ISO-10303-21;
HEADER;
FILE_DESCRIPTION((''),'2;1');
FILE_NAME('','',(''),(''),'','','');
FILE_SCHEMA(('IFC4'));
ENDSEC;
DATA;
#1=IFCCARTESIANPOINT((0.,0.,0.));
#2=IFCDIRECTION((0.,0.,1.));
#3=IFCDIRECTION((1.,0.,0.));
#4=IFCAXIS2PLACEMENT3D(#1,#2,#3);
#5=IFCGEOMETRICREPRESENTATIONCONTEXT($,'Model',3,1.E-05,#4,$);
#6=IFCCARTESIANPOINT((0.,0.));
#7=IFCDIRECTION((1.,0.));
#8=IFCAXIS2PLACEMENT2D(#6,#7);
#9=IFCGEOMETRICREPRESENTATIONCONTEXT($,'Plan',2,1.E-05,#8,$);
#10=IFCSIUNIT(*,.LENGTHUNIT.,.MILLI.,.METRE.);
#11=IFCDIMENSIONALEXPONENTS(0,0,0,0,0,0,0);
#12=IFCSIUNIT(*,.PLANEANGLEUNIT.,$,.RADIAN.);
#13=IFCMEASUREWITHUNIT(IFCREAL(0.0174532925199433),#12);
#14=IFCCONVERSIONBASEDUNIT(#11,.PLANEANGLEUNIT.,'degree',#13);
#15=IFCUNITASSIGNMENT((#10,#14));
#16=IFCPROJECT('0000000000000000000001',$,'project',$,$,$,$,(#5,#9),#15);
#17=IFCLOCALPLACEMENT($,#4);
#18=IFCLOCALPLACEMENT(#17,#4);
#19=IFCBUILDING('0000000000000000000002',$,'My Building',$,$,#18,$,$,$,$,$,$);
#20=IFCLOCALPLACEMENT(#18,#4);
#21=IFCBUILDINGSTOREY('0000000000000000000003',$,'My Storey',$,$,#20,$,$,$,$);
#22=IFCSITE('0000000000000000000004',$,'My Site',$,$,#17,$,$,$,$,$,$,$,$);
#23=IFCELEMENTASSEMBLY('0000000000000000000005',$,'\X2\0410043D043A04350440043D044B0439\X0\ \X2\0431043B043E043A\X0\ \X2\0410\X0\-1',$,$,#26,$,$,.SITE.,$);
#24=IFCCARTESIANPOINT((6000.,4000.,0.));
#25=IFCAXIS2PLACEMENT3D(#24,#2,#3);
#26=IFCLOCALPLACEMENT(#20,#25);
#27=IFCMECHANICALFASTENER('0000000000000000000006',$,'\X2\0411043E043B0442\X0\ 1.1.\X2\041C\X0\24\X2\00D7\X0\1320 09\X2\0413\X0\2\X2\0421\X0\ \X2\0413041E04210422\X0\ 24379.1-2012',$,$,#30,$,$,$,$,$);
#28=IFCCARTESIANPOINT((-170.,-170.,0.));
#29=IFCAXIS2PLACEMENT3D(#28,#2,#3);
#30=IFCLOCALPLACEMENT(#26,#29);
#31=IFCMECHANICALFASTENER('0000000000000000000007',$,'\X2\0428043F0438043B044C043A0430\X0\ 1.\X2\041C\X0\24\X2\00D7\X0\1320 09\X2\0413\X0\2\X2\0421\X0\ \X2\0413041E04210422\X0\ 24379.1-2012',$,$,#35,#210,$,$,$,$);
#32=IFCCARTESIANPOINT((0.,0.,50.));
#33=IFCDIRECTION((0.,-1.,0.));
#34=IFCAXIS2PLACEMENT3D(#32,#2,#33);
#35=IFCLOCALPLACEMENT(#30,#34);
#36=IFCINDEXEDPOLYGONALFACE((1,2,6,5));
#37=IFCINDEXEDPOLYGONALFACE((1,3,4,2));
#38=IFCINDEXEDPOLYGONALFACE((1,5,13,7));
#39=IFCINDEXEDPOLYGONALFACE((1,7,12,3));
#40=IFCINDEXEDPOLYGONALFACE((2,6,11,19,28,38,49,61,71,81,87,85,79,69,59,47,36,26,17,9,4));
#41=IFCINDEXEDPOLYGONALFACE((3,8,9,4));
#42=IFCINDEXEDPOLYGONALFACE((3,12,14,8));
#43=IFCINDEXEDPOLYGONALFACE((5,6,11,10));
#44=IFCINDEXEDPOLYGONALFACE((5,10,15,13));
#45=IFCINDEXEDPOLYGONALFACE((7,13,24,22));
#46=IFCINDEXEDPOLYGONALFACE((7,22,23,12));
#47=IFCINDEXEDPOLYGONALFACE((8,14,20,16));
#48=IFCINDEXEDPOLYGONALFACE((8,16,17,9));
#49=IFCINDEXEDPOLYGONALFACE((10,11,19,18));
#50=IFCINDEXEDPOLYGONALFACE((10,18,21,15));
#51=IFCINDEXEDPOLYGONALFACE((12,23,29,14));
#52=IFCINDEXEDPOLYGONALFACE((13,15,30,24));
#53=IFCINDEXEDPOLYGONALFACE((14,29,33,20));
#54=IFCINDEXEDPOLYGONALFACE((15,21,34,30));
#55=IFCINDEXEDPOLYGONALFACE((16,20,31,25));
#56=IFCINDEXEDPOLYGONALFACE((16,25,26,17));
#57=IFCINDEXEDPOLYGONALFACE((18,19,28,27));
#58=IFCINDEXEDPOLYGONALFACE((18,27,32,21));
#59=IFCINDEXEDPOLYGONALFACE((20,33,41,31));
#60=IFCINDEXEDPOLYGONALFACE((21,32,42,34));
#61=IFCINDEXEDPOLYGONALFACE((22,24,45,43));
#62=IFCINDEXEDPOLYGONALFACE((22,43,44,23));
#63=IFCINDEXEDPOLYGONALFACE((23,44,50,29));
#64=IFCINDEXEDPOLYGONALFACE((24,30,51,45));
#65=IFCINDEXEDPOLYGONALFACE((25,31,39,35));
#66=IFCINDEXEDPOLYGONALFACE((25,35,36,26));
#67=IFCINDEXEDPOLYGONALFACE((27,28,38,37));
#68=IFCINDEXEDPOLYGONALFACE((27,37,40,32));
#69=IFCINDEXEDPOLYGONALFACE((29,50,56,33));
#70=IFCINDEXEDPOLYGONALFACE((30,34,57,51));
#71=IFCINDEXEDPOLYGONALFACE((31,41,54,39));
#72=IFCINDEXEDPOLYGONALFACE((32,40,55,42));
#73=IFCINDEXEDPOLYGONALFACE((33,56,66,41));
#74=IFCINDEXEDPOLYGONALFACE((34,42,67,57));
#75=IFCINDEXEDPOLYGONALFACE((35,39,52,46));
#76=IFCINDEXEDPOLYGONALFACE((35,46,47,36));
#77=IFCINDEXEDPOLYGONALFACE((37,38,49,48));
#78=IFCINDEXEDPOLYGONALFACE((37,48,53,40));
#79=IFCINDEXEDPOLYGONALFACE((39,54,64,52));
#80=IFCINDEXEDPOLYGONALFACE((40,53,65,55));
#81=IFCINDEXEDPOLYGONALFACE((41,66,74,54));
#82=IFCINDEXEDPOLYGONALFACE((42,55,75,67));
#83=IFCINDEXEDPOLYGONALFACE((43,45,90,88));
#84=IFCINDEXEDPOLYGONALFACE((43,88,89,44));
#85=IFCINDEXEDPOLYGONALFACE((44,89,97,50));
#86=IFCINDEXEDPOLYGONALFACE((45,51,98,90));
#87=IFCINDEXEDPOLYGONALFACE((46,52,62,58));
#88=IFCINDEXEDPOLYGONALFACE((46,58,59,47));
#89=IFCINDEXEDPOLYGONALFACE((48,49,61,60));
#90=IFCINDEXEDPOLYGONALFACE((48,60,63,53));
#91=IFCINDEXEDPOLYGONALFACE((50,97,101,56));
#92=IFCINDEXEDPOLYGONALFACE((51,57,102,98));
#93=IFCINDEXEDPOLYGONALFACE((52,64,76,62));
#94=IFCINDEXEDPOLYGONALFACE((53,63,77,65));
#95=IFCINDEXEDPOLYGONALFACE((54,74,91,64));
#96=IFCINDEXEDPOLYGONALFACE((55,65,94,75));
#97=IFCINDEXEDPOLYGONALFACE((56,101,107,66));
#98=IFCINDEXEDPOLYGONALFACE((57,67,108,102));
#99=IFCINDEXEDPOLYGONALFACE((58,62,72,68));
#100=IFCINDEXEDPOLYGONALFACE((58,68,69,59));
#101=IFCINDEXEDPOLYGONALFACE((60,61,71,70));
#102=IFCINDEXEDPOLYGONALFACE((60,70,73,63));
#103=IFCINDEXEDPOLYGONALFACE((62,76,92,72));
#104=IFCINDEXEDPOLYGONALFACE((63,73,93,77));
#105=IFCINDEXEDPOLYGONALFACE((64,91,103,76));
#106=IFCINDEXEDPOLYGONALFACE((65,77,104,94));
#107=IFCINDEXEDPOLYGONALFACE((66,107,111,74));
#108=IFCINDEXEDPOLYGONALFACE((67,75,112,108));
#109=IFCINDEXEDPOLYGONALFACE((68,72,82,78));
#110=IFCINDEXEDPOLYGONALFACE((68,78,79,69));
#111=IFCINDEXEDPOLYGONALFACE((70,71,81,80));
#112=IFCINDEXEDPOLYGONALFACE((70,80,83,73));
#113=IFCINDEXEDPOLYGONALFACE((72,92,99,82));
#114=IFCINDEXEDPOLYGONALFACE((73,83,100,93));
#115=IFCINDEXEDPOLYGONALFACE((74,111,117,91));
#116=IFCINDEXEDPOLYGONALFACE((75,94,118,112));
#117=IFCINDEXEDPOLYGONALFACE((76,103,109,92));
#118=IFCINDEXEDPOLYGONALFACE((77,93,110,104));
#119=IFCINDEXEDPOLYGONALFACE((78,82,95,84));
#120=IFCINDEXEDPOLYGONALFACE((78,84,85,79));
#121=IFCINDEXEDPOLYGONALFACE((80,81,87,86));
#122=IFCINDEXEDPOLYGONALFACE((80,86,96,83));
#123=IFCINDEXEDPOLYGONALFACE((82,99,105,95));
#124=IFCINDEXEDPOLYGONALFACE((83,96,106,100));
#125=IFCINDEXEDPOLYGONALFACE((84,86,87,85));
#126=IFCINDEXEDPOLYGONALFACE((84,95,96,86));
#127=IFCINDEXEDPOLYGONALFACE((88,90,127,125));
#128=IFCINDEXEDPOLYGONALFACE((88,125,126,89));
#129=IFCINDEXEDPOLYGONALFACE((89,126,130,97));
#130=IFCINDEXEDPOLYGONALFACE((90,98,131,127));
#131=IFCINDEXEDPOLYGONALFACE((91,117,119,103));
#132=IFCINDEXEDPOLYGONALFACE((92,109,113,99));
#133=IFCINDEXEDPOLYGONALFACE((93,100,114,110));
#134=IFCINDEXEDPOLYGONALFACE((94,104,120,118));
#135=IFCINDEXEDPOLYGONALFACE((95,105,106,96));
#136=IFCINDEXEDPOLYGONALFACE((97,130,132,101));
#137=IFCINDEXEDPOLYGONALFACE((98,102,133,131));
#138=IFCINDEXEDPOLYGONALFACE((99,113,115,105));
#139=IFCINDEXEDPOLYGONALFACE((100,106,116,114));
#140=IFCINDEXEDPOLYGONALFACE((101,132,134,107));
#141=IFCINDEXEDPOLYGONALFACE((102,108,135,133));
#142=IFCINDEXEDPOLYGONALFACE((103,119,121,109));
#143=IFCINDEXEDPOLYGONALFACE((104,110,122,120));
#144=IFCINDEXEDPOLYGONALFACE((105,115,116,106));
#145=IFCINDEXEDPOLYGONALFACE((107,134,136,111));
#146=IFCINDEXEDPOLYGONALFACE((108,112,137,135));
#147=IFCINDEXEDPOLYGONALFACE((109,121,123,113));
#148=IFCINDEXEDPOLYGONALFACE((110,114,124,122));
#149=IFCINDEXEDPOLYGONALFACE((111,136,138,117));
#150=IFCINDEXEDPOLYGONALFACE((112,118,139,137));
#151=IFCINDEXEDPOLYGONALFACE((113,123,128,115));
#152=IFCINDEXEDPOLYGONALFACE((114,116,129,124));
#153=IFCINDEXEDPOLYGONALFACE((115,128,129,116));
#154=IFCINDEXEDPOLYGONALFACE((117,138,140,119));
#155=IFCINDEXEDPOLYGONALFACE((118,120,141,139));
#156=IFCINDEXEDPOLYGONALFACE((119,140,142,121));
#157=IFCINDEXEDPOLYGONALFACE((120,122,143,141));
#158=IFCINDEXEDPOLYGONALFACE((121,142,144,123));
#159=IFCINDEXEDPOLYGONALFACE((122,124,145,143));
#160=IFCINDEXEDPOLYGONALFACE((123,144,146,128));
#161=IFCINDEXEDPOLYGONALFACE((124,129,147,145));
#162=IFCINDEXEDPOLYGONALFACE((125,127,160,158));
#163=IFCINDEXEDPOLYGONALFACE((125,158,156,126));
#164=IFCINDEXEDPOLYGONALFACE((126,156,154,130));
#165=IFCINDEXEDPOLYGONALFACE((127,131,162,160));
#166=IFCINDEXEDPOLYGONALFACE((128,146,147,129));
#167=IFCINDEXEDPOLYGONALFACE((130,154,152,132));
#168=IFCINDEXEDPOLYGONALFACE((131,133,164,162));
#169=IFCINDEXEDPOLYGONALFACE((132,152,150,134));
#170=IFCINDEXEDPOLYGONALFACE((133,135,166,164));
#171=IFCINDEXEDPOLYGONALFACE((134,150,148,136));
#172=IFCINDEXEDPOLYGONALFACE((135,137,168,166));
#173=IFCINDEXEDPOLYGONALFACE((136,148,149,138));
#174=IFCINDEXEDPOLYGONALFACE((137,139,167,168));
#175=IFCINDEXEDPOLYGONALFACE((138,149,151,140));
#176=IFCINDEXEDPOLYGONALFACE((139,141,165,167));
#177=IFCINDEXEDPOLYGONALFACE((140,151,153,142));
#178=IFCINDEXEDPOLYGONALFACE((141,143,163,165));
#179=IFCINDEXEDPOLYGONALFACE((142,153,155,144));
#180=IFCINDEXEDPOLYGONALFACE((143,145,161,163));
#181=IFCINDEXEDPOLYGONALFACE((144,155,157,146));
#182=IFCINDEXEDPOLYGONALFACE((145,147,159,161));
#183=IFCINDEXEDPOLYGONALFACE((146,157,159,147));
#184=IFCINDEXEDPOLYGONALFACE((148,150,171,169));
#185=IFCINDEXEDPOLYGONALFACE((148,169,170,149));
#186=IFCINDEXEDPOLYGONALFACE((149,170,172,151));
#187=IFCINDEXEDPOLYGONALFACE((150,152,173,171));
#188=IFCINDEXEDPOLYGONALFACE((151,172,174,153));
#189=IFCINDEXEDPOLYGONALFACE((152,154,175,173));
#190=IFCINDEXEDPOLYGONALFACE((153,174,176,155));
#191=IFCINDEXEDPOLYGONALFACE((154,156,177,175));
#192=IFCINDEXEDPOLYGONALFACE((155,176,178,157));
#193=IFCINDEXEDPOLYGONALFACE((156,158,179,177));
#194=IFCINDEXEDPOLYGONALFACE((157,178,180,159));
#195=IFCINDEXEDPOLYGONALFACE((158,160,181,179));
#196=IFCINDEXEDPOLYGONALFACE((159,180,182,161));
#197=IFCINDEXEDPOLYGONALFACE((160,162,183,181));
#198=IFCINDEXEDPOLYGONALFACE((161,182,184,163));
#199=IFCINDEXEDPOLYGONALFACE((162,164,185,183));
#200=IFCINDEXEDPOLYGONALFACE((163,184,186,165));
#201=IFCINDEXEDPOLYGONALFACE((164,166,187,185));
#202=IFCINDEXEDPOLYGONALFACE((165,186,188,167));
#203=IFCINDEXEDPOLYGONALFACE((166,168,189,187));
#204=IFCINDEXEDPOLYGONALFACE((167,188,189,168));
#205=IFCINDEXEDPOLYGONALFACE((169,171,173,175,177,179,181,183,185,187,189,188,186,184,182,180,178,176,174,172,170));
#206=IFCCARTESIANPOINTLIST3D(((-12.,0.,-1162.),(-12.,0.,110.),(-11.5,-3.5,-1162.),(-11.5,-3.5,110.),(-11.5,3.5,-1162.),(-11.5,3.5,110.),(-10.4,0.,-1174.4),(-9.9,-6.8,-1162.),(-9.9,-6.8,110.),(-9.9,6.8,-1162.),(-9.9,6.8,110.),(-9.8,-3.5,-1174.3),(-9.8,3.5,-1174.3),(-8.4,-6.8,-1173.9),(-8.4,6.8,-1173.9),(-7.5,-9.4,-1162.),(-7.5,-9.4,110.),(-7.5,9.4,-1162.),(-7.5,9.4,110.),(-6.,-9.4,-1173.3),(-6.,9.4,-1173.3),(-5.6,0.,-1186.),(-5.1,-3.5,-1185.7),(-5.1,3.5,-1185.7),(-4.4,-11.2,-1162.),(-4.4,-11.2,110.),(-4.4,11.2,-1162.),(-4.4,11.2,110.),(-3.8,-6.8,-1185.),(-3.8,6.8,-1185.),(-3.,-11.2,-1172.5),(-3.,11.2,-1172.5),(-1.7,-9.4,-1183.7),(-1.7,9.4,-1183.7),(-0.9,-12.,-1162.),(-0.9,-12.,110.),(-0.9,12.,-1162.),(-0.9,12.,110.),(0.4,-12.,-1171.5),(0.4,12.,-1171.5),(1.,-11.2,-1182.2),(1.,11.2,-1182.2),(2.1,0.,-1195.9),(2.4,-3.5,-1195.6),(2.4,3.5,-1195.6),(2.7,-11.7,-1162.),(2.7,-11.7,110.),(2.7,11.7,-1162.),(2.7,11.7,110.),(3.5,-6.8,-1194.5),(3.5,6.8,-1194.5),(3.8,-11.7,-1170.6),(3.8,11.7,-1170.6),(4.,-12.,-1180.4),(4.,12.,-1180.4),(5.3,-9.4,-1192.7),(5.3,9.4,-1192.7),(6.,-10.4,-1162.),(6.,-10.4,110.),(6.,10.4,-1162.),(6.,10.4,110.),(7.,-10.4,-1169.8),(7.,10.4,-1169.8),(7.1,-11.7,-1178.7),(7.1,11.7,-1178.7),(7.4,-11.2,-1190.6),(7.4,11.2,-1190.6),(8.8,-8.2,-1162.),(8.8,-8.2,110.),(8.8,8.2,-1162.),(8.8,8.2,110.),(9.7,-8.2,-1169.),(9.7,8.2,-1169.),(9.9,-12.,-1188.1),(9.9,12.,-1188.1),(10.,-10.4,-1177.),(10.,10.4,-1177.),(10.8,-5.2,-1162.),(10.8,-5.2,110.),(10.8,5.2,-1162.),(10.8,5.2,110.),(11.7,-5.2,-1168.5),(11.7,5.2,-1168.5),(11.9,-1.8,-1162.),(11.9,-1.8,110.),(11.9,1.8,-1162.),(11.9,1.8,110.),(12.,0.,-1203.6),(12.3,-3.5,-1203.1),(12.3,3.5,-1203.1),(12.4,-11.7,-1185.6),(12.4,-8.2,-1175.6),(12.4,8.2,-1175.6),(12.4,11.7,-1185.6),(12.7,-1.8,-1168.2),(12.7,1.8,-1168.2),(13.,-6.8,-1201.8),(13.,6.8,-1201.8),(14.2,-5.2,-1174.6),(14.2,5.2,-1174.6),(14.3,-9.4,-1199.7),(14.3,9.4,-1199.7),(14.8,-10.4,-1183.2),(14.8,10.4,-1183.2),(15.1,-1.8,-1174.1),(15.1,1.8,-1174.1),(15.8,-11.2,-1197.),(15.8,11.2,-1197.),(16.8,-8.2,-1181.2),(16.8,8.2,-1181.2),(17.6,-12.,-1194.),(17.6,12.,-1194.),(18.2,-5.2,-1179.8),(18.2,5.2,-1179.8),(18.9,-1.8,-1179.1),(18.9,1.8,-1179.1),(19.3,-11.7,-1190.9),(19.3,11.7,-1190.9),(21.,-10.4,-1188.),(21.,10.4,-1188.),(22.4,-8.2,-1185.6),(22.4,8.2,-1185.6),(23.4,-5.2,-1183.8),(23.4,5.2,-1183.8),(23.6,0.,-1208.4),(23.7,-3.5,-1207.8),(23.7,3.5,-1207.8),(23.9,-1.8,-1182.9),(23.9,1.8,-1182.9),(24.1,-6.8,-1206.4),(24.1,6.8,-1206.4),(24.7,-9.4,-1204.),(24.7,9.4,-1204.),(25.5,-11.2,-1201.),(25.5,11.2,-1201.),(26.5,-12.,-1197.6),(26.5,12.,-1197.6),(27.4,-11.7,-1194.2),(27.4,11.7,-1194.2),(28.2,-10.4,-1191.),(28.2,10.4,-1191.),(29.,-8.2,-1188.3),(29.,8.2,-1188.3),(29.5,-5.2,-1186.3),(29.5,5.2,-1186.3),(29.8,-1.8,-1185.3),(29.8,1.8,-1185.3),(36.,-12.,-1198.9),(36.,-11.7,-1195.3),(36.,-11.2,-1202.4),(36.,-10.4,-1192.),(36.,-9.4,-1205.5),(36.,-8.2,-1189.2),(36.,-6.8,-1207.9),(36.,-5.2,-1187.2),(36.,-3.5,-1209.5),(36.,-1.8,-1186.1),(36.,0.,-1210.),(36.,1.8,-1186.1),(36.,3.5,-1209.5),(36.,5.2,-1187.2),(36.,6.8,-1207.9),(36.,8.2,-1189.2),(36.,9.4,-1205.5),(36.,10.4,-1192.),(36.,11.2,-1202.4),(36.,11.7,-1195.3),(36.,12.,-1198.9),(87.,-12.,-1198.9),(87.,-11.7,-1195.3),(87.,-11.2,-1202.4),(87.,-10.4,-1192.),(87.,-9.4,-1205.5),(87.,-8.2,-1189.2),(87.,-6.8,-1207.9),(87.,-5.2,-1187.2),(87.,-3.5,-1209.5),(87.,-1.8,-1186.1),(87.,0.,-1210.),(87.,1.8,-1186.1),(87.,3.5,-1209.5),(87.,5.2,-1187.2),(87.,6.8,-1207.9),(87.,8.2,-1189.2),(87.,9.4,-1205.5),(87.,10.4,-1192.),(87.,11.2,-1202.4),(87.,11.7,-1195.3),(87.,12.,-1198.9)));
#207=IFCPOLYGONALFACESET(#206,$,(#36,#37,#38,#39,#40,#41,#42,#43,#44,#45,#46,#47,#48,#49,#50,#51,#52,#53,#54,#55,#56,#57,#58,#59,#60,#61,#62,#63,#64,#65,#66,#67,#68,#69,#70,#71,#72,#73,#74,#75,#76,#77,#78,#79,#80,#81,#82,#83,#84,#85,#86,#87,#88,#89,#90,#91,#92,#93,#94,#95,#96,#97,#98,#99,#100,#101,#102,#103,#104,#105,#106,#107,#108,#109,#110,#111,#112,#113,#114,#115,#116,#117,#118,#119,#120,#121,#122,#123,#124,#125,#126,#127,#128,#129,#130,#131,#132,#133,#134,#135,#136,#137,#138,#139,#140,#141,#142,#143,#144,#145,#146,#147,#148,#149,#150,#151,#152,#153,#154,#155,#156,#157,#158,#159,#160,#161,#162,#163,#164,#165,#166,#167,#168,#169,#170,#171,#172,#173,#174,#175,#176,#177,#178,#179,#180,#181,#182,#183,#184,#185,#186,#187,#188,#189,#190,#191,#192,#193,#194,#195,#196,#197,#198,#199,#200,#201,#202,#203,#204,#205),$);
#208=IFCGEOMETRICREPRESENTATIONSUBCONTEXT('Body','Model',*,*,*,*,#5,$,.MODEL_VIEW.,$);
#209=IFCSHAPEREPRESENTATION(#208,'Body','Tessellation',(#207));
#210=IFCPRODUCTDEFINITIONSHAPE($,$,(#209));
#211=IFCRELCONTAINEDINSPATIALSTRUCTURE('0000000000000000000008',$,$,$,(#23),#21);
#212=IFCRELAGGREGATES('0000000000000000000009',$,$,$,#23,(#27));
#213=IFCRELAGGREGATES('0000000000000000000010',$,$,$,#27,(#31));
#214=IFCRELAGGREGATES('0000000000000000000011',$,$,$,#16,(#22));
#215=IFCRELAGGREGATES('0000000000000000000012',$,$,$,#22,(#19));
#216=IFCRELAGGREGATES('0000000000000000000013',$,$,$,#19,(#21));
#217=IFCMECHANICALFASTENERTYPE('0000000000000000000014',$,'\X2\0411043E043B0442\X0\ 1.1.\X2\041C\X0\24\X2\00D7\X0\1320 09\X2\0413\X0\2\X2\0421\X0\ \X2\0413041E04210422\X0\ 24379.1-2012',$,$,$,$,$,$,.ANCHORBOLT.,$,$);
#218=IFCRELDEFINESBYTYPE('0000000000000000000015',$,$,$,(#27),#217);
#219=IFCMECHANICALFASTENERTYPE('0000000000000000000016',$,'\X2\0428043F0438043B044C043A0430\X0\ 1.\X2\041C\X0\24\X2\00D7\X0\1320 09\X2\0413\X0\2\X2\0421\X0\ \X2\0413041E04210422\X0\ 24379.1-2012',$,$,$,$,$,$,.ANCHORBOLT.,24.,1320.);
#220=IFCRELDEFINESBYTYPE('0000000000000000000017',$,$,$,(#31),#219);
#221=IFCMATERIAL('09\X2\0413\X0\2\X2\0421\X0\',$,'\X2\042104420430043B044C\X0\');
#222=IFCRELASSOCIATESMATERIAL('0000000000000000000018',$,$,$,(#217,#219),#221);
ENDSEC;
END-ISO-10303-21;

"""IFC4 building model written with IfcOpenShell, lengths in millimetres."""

from ifc_helpers import new_model, entity, si_unit, converted_unit, frame, origin_with_axes, origin_2d_with_axis, place, context, subcontext, project, spatial, source, transform, mapped, material, type_object, type_shapes, element, aggregate, save


model = new_model("IFC4")

# Units and contexts
model_context = context("Model", 3, precision=1e-05, world=origin_with_axes())
plan_context = context("Plan", 2, precision=1e-05, world=origin_2d_with_axis())
body_context = subcontext(model_context, "Body", "Model", "MODEL_VIEW")
ifc_project = project(units=[si_unit("LENGTHUNIT", "METRE", prefix="MILLI"), converted_unit("PLANEANGLEUNIT", "degree", entity("IfcReal", 0.0174532925199433), si_unit("PLANEANGLEUNIT", "RADIAN"), dimensions=[0, 0, 0, 0, 0, 0, 0])], contexts=[model_context, plan_context])

# Site, building, storey
site_placement = place(None, origin_with_axes())
site = spatial("IfcSite", under=ifc_project, at=site_placement, Name="My Site")
building_placement = place(site_placement, origin_with_axes())
building = spatial("IfcBuilding", under=site, at=building_placement, Name="My Building")
storey_placement = place(building_placement, origin_with_axes())
storey = spatial("IfcBuildingStorey", under=building, at=storey_placement, Name="My Storey")

# Element assembly, mechanical fasteners
ifc_material_1 = material(Name="09Г2С", Category="Сталь")
mechanical_fastener_type_1 = type_object("IfcMechanicalFastenerType", Name="Болт 1.1.М24×1320 09Г2С ГОСТ 24379.1-2012", PredefinedType="ANCHORBOLT", material=ifc_material_1)
mechanical_fastener_type_2 = type_object("IfcMechanicalFastenerType", Name="Шпилька 1.М24×1320 09Г2С ГОСТ 24379.1-2012", NominalDiameter=24.0, NominalLength=1320.0, PredefinedType="ANCHORBOLT", material=ifc_material_1)
shared_shape_1 = source(frame((0.0, 0.0, 110.0), z_axis=(0.0, 0.0, 1.0), x_axis=(1.0, 0.0, 0.0)), body_context, "Body", "AdvancedSweptSolid", [
    entity("IfcSweptDiskSolid", entity("IfcIndexedPolyCurve", entity("IfcCartesianPointList3D", [[0.0, 0.0, 0.0], [0.0, 0.0, -1272.0], [10.5, 0.0, -1297.5], [36.0, 0.0, -1308.0], [87.0, 0.0, -1308.0]]), [entity("IfcLineIndex", [1, 2]), entity("IfcArcIndex", [2, 3, 4]), entity("IfcLineIndex", [4, 5])]), 12.0),
])
type_shapes(mechanical_fastener_type_2, [shared_shape_1])
assembly_1_placement = place(storey_placement, frame((6000.0, 4000.0, 0.0), z_axis=(0.0, 0.0, 1.0), x_axis=(1.0, 0.0, 0.0)))
assembly_1 = element("IfcElementAssembly", 1, at=assembly_1_placement, inside=storey, Name="Анкерный блок А-1", AssemblyPlace="SITE")
mechanical_fastener_1_placement = place(assembly_1_placement, frame((-170.0, -170.0, 0.0), z_axis=(0.0, 0.0, 1.0), x_axis=(1.0, 0.0, 0.0)))
mechanical_fastener_1 = element("IfcMechanicalFastener", 2, at=mechanical_fastener_1_placement, type_object=mechanical_fastener_type_1, Name="Болт 1.1.М24×1320 09Г2С ГОСТ 24379.1-2012")
mechanical_fastener_2_placement = place(mechanical_fastener_1_placement, frame((0.0, 0.0, 50.0), z_axis=(0.0, 0.0, 1.0), x_axis=(0.0, -1.0, 0.0)))
mechanical_fastener_2 = element("IfcMechanicalFastener", 3, at=mechanical_fastener_2_placement, type_object=mechanical_fastener_type_2, Name="Шпилька 1.М24×1320 09Г2С ГОСТ 24379.1-2012", context=body_context, shape_type="MappedRepresentation", body=[
    mapped(shared_shape_1, transform((0.0, 0.0, 0.0), x_axis=(1.0, 0.0, 0.0), y_axis=(0.0, 1.0, 0.0), z_axis=(0.0, 0.0, 1.0), scale=1.0)),
])
aggregate(assembly_1, [mechanical_fastener_1])

aggregate(mechanical_fastener_1, [mechanical_fastener_2])

save(model, "model.ifc")
